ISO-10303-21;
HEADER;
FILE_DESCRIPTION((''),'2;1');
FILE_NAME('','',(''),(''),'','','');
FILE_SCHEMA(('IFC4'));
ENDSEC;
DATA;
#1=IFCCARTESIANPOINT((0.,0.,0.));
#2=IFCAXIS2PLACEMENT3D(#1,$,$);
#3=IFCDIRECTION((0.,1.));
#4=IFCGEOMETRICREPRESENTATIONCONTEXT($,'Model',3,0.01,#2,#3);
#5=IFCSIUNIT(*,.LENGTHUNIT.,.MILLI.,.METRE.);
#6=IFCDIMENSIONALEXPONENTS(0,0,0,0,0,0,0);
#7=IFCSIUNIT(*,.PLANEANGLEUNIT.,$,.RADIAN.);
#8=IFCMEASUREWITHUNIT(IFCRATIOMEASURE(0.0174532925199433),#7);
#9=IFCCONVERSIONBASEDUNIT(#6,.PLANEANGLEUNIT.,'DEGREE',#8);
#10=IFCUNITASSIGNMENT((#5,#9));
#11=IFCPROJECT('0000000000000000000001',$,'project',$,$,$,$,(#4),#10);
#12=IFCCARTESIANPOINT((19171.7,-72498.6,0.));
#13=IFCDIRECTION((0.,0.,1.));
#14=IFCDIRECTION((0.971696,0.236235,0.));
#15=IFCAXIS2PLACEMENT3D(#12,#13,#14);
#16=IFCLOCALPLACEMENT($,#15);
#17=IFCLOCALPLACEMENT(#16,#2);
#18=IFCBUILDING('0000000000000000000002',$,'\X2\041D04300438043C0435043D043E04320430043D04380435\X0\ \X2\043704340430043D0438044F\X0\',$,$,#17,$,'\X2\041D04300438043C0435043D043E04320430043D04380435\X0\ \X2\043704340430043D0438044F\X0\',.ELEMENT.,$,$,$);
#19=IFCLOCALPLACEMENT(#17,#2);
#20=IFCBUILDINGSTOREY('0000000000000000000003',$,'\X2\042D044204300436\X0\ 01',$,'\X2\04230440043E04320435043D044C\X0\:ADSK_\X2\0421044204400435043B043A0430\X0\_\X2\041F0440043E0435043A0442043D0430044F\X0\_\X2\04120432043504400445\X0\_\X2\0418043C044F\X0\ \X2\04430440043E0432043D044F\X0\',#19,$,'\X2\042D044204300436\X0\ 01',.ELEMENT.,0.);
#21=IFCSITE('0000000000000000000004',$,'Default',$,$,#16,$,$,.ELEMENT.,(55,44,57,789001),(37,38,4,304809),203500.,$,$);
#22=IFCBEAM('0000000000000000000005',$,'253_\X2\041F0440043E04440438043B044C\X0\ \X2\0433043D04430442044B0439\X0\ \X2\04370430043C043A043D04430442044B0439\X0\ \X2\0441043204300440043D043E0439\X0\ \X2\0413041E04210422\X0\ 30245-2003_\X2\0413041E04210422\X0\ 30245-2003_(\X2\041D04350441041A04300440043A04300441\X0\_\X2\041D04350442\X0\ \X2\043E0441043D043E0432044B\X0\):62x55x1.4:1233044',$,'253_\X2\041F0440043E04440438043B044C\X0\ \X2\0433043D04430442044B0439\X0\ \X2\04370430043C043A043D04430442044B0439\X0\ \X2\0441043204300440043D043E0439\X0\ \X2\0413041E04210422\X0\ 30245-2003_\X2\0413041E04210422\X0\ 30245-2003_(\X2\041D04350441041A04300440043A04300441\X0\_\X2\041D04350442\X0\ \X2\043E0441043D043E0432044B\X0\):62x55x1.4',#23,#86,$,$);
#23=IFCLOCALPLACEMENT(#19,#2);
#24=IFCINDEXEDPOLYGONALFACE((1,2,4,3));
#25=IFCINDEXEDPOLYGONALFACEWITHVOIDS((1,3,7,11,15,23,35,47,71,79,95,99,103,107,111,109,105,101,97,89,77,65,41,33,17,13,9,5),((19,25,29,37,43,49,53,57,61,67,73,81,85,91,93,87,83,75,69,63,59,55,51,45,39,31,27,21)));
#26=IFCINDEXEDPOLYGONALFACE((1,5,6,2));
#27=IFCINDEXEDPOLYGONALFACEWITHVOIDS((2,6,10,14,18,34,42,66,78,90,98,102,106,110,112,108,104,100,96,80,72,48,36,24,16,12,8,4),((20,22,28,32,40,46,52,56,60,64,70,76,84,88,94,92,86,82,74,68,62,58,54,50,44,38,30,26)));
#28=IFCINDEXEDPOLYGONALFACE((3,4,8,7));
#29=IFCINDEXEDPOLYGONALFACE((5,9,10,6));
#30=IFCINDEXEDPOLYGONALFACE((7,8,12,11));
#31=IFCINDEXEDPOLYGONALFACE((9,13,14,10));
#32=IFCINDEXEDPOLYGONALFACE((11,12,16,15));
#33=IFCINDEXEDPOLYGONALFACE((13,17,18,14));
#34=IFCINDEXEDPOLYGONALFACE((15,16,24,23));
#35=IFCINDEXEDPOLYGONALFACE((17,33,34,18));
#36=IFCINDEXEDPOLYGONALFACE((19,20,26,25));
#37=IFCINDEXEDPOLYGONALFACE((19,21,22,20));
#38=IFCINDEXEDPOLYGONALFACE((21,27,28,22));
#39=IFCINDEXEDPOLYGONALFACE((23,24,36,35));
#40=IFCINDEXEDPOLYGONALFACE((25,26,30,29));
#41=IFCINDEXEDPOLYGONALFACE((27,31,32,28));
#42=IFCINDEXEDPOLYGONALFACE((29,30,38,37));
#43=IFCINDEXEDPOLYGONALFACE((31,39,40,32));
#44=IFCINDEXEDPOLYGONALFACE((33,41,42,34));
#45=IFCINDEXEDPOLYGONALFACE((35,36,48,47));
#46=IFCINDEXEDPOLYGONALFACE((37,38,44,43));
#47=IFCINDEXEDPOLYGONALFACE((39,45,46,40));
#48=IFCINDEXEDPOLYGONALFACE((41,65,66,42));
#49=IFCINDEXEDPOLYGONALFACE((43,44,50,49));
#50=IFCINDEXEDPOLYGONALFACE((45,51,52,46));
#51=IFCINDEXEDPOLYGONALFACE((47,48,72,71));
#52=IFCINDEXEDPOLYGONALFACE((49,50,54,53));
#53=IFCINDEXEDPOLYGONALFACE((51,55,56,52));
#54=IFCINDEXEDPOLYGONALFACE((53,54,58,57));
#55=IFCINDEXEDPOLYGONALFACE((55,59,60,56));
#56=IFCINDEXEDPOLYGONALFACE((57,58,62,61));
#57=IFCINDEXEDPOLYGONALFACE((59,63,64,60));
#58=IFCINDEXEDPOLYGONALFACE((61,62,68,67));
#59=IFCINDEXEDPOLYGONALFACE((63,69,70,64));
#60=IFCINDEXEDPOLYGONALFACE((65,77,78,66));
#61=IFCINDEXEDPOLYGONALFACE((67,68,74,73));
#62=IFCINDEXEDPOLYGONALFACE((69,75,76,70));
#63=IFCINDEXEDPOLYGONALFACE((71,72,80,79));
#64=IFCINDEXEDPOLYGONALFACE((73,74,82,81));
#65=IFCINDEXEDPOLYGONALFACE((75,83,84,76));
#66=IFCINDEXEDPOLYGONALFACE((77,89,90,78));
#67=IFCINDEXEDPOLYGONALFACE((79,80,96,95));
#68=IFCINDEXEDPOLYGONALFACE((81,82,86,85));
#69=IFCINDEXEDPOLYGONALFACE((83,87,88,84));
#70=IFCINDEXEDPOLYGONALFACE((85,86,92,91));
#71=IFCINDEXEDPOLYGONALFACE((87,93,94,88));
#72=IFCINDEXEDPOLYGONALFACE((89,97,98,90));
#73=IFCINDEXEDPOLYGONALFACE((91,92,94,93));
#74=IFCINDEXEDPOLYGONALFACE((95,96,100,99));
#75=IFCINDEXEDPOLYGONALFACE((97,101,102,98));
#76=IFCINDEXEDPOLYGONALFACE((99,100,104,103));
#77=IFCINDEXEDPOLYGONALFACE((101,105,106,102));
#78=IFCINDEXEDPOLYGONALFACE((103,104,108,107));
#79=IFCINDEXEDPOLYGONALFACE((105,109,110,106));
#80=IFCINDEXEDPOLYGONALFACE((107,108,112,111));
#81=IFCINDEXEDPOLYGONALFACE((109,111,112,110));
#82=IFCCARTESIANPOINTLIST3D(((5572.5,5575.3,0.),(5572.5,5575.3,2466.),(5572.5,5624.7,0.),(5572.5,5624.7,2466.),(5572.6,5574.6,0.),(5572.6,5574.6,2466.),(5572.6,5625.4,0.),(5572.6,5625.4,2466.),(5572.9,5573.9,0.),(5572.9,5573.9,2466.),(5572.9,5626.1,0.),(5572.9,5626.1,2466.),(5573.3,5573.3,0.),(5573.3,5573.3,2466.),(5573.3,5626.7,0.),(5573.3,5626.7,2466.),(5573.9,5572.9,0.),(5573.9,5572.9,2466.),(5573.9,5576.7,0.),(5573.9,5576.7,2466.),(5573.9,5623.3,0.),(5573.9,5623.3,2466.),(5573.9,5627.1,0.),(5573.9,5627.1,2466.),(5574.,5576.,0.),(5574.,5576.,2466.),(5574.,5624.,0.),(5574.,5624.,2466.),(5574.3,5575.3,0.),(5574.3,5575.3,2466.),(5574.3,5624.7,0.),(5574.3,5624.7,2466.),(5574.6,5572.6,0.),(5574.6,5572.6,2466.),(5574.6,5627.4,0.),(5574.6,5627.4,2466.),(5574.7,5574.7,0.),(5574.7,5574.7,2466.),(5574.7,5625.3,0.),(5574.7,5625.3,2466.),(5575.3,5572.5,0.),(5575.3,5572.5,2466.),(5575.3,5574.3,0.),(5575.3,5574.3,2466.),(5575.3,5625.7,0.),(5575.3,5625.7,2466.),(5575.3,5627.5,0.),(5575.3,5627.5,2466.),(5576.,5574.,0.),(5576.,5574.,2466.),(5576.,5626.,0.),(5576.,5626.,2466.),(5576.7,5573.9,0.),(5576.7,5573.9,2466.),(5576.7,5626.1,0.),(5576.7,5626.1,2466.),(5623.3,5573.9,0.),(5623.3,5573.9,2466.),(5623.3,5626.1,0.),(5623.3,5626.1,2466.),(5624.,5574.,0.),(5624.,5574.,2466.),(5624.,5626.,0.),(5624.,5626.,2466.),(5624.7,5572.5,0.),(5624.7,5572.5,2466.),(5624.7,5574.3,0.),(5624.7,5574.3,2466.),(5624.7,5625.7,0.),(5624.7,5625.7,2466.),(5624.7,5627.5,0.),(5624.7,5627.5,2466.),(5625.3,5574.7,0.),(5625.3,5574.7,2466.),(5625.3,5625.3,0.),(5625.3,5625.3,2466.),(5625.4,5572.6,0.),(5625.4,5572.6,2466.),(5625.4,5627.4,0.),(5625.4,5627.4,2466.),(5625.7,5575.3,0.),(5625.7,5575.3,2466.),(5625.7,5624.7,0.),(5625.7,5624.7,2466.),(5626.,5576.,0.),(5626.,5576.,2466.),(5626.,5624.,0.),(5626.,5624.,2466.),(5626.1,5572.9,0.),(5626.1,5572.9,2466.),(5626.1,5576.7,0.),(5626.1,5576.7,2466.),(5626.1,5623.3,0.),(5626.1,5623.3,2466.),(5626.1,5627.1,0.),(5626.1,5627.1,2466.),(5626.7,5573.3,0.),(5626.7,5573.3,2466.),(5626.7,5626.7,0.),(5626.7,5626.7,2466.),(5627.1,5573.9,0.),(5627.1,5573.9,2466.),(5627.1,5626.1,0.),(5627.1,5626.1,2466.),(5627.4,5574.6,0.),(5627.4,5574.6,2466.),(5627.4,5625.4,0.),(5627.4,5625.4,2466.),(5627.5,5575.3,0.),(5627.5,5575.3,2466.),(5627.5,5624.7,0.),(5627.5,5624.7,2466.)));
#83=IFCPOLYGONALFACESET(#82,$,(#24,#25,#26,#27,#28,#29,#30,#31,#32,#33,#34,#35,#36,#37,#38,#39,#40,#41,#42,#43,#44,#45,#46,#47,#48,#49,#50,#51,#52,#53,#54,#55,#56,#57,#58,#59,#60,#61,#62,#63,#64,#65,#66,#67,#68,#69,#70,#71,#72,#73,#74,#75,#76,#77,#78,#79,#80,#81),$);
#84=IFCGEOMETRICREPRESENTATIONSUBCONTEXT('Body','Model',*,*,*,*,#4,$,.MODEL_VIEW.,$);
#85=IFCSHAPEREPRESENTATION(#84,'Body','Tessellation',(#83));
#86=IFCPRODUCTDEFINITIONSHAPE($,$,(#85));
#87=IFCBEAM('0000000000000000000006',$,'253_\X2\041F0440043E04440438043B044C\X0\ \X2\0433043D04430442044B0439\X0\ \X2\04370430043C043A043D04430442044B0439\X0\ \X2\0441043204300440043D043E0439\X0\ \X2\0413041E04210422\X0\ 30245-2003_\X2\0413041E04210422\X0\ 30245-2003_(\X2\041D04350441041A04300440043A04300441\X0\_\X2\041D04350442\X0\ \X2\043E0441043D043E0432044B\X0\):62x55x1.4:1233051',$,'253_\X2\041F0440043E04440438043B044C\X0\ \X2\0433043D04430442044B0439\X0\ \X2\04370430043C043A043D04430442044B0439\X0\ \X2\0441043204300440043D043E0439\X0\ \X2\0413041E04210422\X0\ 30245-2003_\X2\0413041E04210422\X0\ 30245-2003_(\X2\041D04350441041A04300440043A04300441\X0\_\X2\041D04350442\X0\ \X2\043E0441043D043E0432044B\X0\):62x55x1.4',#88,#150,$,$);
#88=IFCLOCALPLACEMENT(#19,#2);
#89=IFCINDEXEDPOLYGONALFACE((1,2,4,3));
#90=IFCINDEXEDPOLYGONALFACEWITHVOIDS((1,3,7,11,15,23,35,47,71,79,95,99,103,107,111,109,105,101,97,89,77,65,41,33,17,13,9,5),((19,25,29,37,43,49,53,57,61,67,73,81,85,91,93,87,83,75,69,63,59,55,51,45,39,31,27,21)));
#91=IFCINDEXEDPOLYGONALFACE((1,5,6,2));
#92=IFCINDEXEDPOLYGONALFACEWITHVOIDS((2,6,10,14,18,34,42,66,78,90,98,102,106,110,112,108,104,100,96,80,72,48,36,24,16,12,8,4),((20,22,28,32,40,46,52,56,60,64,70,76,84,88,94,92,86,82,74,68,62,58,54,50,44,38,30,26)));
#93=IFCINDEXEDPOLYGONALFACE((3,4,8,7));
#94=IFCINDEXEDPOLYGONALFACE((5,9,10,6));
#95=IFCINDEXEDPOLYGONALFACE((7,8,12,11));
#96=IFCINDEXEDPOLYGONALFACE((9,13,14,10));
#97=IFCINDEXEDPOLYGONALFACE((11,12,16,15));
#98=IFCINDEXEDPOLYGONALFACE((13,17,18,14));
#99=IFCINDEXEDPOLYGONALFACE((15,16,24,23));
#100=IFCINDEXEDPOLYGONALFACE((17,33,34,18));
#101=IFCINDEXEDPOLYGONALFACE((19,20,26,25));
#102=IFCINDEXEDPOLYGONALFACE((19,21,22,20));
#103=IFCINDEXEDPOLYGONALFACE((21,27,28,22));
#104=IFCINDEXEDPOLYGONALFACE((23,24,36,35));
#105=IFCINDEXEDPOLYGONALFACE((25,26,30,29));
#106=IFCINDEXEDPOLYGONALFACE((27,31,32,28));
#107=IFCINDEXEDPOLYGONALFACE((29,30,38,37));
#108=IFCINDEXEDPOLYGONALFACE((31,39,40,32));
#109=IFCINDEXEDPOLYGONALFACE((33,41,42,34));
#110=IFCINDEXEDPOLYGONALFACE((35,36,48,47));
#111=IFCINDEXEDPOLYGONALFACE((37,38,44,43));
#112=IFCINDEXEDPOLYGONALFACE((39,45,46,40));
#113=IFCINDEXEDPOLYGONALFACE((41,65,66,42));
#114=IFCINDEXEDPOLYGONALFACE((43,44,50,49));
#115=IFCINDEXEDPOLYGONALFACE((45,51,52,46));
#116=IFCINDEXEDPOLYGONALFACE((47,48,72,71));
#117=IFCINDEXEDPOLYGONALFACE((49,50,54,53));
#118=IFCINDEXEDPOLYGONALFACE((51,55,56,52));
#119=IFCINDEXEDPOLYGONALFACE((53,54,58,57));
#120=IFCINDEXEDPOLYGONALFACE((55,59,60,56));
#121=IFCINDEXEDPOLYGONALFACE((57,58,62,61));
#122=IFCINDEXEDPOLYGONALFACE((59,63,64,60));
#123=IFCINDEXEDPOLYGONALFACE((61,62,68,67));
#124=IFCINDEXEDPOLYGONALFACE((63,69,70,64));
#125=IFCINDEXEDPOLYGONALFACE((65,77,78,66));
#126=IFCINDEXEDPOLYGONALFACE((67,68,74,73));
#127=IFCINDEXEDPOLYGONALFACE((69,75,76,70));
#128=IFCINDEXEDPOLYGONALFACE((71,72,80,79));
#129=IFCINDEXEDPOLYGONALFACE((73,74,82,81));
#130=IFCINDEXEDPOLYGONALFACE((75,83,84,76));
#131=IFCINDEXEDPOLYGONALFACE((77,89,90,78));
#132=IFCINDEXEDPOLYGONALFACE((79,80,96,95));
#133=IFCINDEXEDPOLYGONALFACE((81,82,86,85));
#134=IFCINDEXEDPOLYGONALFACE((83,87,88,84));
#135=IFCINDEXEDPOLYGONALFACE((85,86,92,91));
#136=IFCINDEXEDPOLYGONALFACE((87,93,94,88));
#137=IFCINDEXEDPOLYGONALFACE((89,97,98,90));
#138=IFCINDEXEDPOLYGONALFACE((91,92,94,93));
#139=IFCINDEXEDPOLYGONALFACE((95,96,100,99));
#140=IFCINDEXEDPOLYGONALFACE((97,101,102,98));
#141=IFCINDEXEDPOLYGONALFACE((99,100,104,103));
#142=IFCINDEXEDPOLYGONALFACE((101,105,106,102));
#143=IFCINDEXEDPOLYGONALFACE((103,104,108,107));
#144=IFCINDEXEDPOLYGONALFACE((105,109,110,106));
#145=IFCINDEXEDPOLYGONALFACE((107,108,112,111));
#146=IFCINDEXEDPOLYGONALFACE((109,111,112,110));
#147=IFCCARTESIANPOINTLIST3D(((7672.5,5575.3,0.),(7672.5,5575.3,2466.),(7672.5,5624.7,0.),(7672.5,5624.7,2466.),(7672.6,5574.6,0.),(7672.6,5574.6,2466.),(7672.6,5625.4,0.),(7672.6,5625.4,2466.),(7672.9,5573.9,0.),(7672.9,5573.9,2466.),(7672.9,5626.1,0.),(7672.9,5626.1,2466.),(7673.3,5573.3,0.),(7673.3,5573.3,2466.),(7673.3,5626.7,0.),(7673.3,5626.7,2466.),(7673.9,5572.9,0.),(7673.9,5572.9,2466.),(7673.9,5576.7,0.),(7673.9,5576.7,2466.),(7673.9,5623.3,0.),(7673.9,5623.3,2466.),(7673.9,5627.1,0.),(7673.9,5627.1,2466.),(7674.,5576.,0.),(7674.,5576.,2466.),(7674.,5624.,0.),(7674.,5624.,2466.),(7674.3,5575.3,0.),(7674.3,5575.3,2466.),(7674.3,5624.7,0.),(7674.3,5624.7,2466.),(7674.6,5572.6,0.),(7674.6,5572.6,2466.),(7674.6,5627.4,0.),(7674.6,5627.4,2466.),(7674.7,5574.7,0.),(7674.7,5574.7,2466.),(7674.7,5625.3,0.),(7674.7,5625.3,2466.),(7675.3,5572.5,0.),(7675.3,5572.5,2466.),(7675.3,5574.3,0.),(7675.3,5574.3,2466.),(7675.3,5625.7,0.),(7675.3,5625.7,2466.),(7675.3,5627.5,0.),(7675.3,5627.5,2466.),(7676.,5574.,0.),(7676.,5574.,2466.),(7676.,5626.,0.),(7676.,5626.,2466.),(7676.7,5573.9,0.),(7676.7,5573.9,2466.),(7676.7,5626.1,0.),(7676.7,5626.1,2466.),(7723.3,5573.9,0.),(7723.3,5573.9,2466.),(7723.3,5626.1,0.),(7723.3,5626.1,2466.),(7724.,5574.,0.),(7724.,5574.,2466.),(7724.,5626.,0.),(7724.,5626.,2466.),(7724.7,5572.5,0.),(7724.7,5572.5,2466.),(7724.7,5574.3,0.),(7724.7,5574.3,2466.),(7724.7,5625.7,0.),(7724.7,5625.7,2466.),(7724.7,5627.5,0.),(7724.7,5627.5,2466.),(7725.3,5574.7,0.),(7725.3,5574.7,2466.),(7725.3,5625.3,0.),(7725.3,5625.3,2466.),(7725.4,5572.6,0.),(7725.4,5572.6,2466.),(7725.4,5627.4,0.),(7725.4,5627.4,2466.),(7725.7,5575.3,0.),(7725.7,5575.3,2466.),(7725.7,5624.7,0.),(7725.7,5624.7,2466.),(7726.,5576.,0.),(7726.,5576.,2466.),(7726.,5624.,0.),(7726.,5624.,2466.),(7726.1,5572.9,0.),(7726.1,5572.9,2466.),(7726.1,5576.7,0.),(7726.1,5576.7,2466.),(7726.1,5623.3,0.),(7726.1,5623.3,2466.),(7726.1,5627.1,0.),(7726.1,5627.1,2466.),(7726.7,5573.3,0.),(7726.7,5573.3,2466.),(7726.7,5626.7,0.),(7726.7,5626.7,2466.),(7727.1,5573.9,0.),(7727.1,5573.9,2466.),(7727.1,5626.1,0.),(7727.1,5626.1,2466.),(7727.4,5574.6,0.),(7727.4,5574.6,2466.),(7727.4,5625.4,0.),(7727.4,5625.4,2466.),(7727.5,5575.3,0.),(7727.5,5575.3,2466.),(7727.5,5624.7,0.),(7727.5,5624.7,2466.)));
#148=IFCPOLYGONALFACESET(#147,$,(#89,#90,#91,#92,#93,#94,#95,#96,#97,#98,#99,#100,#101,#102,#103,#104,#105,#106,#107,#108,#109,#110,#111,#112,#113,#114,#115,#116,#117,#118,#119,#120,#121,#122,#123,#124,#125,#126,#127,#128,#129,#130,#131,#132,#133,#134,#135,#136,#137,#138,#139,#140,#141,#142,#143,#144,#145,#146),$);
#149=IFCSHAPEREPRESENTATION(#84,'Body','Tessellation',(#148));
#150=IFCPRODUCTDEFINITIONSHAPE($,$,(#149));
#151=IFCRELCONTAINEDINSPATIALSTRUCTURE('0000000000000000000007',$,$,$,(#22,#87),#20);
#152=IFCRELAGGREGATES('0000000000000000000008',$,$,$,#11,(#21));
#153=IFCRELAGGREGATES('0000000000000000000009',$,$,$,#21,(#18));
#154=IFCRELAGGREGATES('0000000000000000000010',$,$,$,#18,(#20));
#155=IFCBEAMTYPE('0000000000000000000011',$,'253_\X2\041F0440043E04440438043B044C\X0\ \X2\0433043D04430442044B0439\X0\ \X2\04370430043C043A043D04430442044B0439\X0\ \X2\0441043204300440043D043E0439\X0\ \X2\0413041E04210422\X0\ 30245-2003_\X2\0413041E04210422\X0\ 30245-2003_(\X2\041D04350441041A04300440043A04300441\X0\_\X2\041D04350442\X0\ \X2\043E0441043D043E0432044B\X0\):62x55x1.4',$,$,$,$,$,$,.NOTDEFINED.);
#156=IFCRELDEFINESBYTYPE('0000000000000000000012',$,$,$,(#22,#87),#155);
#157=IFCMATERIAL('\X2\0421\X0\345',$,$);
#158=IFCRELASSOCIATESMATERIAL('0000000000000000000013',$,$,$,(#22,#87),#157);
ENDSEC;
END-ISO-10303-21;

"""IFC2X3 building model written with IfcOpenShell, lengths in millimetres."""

from ifc_helpers import new_model, entity, si_unit, converted_unit, direction, frame, frame_2d, origin, place, context, subcontext, project, spatial, polyline, circle_curve, parameter, trimmed, segment, composite_curve, outline, extrude, material, type_object, element, save


model = new_model("IFC2X3")

# Units and contexts
model_context = context("Model", 3, precision=0.01, world=origin(), true_north=direction((0.0, 1.0)))
body_context = subcontext(model_context, "Body", "Model", "MODEL_VIEW")
ifc_project = project(units=[si_unit("LENGTHUNIT", "METRE", prefix="MILLI"), converted_unit("PLANEANGLEUNIT", "DEGREE", entity("IfcRatioMeasure", 0.0174532925199433), si_unit("PLANEANGLEUNIT", "RADIAN"), dimensions=[0, 0, 0, 0, 0, 0, 0])], contexts=[model_context])

# Site, building, storey
site_placement = place(None, frame((19171.7, -72498.6, 0.0), z_axis=(0.0, 0.0, 1.0), x_axis=(0.971696, 0.236235, 0.0)))
site = spatial("IfcSite", under=ifc_project, at=site_placement, Name="Default", CompositionType="ELEMENT", RefLatitude=(55, 44, 57, 789001), RefLongitude=(37, 38, 4, 304809), RefElevation=203500.0)
building_placement = place(site_placement, origin())
building = spatial("IfcBuilding", under=site, at=building_placement, Name="Наименование здания", LongName="Наименование здания", CompositionType="ELEMENT")
storey_placement = place(building_placement, origin())
storey = spatial("IfcBuildingStorey", under=building, at=storey_placement, Name="Этаж 01", ObjectType="Уровень:ADSK_Стрелка_Проектная_Вверх_Имя уровня", LongName="Этаж 01", CompositionType="ELEMENT", Elevation=0.0)

# Beams
ifc_material_1 = material(Name="С345")
beam_type_1 = type_object("IfcBeamType", Name="253_Профиль гнутый замкнутый сварной ГОСТ 30245-2003_ГОСТ 30245-2003_(НесКаркас_Нет основы):62x55x1.4", PredefinedType="NOTDEFINED")
beam_1_placement = place(storey_placement, frame((5570.9, 5570.9, 0.0), z_axis=(1.0, 0.0, 0.0), x_axis=(0.0, 0.0, -1.0)))
element("IfcBeam", 1, at=beam_1_placement, inside=storey, type_object=beam_type_1, material=ifc_material_1, Name="253_Профиль гнутый замкнутый сварной ГОСТ 30245-2003_ГОСТ 30245-2003_(НесКаркас_Нет основы):62x55x1.4:1233044", ObjectType="253_Профиль гнутый замкнутый сварной ГОСТ 30245-2003_ГОСТ 30245-2003_(НесКаркас_Нет основы):62x55x1.4", context=body_context, shape_type="SweptSolid", body=[
    extrude(outline(composite_curve([segment(trimmed(circle_curve(frame_2d((24.7, -24.7), x_axis=(1.0, 0.0)), 2.8), [parameter(270.0)], [parameter(0.0)], True, "PARAMETER"), True, "CONTINUOUS"), segment(polyline([(27.5, -24.7), (27.5, 24.7)]), True, "CONTINUOUS"), segment(trimmed(circle_curve(frame_2d((24.7, 24.7), x_axis=(1.0, 0.0)), 2.8), [parameter(0.0)], [parameter(90.0)], True, "PARAMETER"), True, "CONTINUOUS"), segment(polyline([(24.7, 27.5), (-24.7, 27.5)]), True, "CONTINUOUS"), segment(trimmed(circle_curve(frame_2d((-24.7, 24.7), x_axis=(1.0, 0.0)), 2.8), [parameter(90.0)], [parameter(180.0)], True, "PARAMETER"), True, "CONTINUOUS"), segment(polyline([(-27.5, 24.7), (-27.5, -24.7)]), True, "CONTINUOUS"), segment(trimmed(circle_curve(frame_2d((-24.7, -24.7), x_axis=(1.0, 0.0)), 2.8), [parameter(180.0)], [parameter(270.0)], True, "PARAMETER"), True, "CONTINUOUS"), segment(polyline([(-24.7, -27.5), (24.7, -27.5)]), True, "CONTINUOUS")], self_intersect=False), holes=[composite_curve([segment(polyline([(23.3, -26.1), (-23.3, -26.1)]), True, "CONTINUOUS"), segment(trimmed(circle_curve(frame_2d((-23.3, -23.3), x_axis=(1.0, 0.0)), 2.8), [parameter(180.0)], [parameter(270.0)], True, "PARAMETER"), False, "CONTINUOUS"), segment(polyline([(-26.1, -23.3), (-26.1, 23.3)]), True, "CONTINUOUS"), segment(trimmed(circle_curve(frame_2d((-23.3, 23.3), x_axis=(1.0, 0.0)), 2.8), [parameter(90.0)], [parameter(180.0)], True, "PARAMETER"), False, "CONTINUOUS"), segment(polyline([(-23.3, 26.1), (23.3, 26.1)]), True, "CONTINUOUS"), segment(trimmed(circle_curve(frame_2d((23.3, 23.3), x_axis=(1.0, 0.0)), 2.8), [parameter(0.0)], [parameter(90.0)], True, "PARAMETER"), False, "CONTINUOUS"), segment(polyline([(26.1, 23.3), (26.1, -23.3)]), True, "CONTINUOUS"), segment(trimmed(circle_curve(frame_2d((23.3, -23.3), x_axis=(1.0, 0.0)), 2.8), [parameter(270.0)], [parameter(0.0)], True, "PARAMETER"), False, "CONTINUOUS")], self_intersect=False)]), frame((-2466.0, 29.1, 29.1), z_axis=(1.0, 0.0, 0.0), x_axis=(0.0, 1.0, 0.0)), (0.0, 0.0, 1.0), 2466.0),
])
beam_2_placement = place(storey_placement, frame((7670.9, 5570.9, 0.0), z_axis=(1.0, 0.0, 0.0), x_axis=(0.0, 0.0, -1.0)))
element("IfcBeam", 2, at=beam_2_placement, inside=storey, type_object=beam_type_1, material=ifc_material_1, Name="253_Профиль гнутый замкнутый сварной ГОСТ 30245-2003_ГОСТ 30245-2003_(НесКаркас_Нет основы):62x55x1.4:1233051", ObjectType="253_Профиль гнутый замкнутый сварной ГОСТ 30245-2003_ГОСТ 30245-2003_(НесКаркас_Нет основы):62x55x1.4", context=body_context, shape_type="SweptSolid", body=[
    extrude(outline(composite_curve([segment(trimmed(circle_curve(frame_2d((24.7, -24.7), x_axis=(1.0, 0.0)), 2.8), [parameter(270.0)], [parameter(0.0)], True, "PARAMETER"), True, "CONTINUOUS"), segment(polyline([(27.5, -24.7), (27.5, 24.7)]), True, "CONTINUOUS"), segment(trimmed(circle_curve(frame_2d((24.7, 24.7), x_axis=(1.0, 0.0)), 2.8), [parameter(0.0)], [parameter(90.0)], True, "PARAMETER"), True, "CONTINUOUS"), segment(polyline([(24.7, 27.5), (-24.7, 27.5)]), True, "CONTINUOUS"), segment(trimmed(circle_curve(frame_2d((-24.7, 24.7), x_axis=(1.0, 0.0)), 2.8), [parameter(90.0)], [parameter(180.0)], True, "PARAMETER"), True, "CONTINUOUS"), segment(polyline([(-27.5, 24.7), (-27.5, -24.7)]), True, "CONTINUOUS"), segment(trimmed(circle_curve(frame_2d((-24.7, -24.7), x_axis=(1.0, 0.0)), 2.8), [parameter(180.0)], [parameter(270.0)], True, "PARAMETER"), True, "CONTINUOUS"), segment(polyline([(-24.7, -27.5), (24.7, -27.5)]), True, "CONTINUOUS")], self_intersect=False), holes=[composite_curve([segment(polyline([(23.3, -26.1), (-23.3, -26.1)]), True, "CONTINUOUS"), segment(trimmed(circle_curve(frame_2d((-23.3, -23.3), x_axis=(1.0, 0.0)), 2.8), [parameter(180.0)], [parameter(270.0)], True, "PARAMETER"), False, "CONTINUOUS"), segment(polyline([(-26.1, -23.3), (-26.1, 23.3)]), True, "CONTINUOUS"), segment(trimmed(circle_curve(frame_2d((-23.3, 23.3), x_axis=(1.0, 0.0)), 2.8), [parameter(90.0)], [parameter(180.0)], True, "PARAMETER"), False, "CONTINUOUS"), segment(polyline([(-23.3, 26.1), (23.3, 26.1)]), True, "CONTINUOUS"), segment(trimmed(circle_curve(frame_2d((23.3, 23.3), x_axis=(1.0, 0.0)), 2.8), [parameter(0.0)], [parameter(90.0)], True, "PARAMETER"), False, "CONTINUOUS"), segment(polyline([(26.1, 23.3), (26.1, -23.3)]), True, "CONTINUOUS"), segment(trimmed(circle_curve(frame_2d((23.3, -23.3), x_axis=(1.0, 0.0)), 2.8), [parameter(270.0)], [parameter(0.0)], True, "PARAMETER"), False, "CONTINUOUS")], self_intersect=False)]), frame((-2466.0, 29.1, 29.1), z_axis=(1.0, 0.0, 0.0), x_axis=(0.0, 1.0, 0.0)), (0.0, 0.0, 1.0), 2466.0),
])

save(model, "model.ifc")
